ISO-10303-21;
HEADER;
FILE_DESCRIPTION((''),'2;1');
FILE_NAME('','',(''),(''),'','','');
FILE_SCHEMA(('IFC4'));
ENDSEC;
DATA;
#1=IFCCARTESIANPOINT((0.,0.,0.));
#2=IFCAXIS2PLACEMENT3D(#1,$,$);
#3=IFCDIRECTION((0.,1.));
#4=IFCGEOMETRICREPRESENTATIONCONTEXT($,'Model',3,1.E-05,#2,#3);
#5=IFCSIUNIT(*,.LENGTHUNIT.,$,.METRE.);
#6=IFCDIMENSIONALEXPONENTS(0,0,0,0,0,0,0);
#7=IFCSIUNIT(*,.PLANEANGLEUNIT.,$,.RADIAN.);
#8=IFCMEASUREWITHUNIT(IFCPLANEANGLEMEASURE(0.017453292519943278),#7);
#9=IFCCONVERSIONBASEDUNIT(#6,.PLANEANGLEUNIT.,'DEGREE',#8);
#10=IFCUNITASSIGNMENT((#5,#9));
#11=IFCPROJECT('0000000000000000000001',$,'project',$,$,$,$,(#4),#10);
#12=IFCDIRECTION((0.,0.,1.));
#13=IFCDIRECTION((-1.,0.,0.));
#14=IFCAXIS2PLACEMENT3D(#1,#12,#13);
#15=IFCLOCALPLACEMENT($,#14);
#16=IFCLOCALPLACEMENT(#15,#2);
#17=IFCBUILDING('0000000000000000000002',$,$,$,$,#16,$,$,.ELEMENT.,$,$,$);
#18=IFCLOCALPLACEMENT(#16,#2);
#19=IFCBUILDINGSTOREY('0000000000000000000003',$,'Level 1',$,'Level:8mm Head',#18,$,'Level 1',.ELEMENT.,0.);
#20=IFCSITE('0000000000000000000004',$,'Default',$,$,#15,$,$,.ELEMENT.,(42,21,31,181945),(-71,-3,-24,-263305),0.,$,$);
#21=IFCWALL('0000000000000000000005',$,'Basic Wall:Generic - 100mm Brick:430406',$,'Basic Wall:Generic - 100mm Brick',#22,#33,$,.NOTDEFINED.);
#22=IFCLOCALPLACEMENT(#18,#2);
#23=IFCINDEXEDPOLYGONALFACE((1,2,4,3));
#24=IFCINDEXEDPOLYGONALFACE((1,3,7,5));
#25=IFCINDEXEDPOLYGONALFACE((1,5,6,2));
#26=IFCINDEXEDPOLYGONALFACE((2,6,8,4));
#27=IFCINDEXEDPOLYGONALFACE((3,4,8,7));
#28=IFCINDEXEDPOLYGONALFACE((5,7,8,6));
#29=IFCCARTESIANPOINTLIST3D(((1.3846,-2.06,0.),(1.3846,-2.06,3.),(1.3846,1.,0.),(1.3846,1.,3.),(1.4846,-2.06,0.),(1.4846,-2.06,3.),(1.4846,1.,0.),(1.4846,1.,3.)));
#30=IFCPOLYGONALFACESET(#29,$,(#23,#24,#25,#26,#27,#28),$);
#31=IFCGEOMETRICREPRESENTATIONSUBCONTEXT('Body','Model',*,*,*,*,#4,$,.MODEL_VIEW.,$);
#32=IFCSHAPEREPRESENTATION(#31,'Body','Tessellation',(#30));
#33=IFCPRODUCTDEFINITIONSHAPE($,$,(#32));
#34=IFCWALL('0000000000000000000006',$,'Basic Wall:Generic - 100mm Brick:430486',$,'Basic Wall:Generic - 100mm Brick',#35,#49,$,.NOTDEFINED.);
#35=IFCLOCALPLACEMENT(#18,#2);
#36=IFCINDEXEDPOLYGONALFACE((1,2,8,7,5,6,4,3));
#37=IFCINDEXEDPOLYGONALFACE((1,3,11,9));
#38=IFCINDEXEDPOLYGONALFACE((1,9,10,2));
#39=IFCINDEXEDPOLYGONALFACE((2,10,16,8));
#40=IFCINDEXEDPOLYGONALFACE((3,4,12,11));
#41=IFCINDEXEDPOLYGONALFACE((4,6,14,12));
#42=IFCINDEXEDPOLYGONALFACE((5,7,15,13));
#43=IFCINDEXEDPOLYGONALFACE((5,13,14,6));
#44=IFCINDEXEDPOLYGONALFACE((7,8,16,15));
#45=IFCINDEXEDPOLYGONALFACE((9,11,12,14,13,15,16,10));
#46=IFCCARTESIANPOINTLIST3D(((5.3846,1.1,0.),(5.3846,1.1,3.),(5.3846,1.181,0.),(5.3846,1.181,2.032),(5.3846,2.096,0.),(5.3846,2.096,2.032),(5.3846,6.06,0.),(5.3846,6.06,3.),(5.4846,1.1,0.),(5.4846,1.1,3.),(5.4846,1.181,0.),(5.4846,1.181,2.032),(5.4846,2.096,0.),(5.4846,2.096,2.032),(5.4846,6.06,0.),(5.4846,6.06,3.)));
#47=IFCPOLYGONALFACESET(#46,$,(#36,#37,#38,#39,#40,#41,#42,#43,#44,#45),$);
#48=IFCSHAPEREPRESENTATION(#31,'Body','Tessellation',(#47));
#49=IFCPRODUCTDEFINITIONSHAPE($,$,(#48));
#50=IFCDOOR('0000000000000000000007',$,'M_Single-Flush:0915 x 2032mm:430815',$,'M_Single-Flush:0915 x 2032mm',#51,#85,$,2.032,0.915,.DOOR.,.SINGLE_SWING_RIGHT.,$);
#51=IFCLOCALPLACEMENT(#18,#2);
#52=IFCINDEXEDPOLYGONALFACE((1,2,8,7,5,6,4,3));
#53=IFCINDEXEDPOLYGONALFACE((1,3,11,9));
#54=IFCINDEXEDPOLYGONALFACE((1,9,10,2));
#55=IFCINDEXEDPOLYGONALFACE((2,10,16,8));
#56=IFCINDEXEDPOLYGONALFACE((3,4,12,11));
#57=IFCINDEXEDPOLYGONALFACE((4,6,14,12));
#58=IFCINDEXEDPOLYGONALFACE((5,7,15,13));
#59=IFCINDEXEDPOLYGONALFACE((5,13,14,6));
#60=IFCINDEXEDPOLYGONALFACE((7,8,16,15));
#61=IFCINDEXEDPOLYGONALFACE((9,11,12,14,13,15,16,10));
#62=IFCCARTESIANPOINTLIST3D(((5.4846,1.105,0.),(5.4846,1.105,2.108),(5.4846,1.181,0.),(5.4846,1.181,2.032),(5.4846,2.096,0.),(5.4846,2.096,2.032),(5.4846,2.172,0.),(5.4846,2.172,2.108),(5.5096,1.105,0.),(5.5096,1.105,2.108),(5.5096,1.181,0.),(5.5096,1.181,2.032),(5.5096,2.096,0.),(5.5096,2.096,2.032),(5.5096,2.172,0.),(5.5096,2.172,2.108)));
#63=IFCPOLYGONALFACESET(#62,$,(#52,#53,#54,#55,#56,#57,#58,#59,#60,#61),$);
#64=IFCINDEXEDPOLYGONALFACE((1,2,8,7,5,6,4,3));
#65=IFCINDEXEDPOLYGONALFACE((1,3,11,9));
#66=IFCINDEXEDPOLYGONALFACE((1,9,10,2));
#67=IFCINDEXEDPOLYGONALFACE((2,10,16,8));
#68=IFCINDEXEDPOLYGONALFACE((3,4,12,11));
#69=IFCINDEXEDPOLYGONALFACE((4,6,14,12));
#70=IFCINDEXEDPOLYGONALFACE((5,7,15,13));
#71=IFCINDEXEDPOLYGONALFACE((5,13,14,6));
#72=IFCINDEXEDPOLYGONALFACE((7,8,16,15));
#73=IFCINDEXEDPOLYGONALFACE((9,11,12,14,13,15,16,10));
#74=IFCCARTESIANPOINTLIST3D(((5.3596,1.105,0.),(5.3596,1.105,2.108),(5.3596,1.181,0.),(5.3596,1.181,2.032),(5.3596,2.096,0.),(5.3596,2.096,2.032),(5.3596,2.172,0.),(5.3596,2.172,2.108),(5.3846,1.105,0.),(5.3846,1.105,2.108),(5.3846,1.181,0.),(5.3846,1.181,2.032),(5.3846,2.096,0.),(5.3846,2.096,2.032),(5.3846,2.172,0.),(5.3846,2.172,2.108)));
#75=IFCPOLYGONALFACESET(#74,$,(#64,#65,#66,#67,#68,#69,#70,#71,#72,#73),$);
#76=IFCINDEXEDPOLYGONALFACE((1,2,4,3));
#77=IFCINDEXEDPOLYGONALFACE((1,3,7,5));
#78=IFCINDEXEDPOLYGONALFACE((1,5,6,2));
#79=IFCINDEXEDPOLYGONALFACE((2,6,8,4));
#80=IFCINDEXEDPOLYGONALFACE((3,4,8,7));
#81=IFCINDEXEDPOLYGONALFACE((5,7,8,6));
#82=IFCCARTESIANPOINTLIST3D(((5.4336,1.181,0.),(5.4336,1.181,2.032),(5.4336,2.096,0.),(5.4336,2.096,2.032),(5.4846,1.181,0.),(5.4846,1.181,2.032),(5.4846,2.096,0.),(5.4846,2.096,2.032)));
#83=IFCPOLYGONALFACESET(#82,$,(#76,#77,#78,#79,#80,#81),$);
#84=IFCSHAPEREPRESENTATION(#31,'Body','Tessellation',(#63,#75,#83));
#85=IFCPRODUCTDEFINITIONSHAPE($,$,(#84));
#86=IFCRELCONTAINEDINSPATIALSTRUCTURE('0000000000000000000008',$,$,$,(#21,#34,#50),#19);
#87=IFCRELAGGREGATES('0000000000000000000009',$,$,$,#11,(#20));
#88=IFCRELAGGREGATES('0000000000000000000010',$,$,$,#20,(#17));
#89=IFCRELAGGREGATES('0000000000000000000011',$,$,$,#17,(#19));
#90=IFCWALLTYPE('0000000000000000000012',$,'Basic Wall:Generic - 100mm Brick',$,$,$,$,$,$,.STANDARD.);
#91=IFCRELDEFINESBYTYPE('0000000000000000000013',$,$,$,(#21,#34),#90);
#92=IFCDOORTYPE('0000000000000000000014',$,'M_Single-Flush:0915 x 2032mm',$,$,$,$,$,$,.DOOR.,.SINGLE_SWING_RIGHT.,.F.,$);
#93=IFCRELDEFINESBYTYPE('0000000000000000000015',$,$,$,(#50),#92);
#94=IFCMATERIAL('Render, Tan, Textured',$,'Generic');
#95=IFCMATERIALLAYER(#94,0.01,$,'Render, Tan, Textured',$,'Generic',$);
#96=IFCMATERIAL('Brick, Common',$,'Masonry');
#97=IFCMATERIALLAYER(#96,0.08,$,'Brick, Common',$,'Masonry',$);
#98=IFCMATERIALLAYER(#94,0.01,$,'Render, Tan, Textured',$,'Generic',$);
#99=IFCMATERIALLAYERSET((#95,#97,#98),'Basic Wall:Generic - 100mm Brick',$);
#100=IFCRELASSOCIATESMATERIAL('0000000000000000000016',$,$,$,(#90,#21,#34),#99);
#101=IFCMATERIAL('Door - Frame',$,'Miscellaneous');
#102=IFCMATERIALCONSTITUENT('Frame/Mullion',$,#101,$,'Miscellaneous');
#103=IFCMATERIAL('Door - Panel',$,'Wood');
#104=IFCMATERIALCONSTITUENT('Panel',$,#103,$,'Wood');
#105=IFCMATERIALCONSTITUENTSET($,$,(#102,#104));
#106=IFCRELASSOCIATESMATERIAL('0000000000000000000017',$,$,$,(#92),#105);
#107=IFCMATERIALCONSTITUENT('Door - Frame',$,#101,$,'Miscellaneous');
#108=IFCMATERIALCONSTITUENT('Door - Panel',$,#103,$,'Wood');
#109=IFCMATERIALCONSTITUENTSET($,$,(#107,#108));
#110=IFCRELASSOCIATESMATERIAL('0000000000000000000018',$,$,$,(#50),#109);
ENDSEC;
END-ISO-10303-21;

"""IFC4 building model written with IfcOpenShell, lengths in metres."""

from ifc_helpers import new_model, entity, si_unit, converted_unit, direction, frame, frame_2d, origin, place, context, subcontext, project, spatial, polyline, rectangle, outline, extrude, source, transform, mapped, material, layer, layer_set, layer_usage, constituent, constituent_set, type_object, type_shapes, element, fill, save


model = new_model("IFC4")

# Units and contexts
model_context = context("Model", 3, precision=1e-05, world=origin(), true_north=direction((0.0, 1.0)))
body_context = subcontext(model_context, "Body", "Model", "MODEL_VIEW")
ifc_project = project(units=[si_unit("LENGTHUNIT", "METRE"), converted_unit("PLANEANGLEUNIT", "DEGREE", entity("IfcPlaneAngleMeasure", 0.017453292519943278), si_unit("PLANEANGLEUNIT", "RADIAN"), dimensions=[0, 0, 0, 0, 0, 0, 0])], contexts=[model_context])

# Site, building, storey
site_placement = place(None, frame((0.0, 0.0, 0.0), z_axis=(0.0, 0.0, 1.0), x_axis=(-1.0, 0.0, 0.0)))
site = spatial("IfcSite", under=ifc_project, at=site_placement, Name="Default", CompositionType="ELEMENT", RefLatitude=(42, 21, 31, 181945), RefLongitude=(-71, -3, -24, -263305), RefElevation=0.0)
building_placement = place(site_placement, origin())
building = spatial("IfcBuilding", under=site, at=building_placement, CompositionType="ELEMENT")
storey_placement = place(building_placement, origin())
storey = spatial("IfcBuildingStorey", under=building, at=storey_placement, Name="Level 1", ObjectType="Level:8mm Head", LongName="Level 1", CompositionType="ELEMENT", Elevation=0.0)

# Shared definitions
ifc_material_1 = material(Name="Brick, Common", Category="Masonry")

# Shared definitions
ifc_material_2 = material(Name="Render, Tan, Textured", Category="Generic")
ifc_layer_1 = layer(ifc_material_2, 0.01, Name="Render, Tan, Textured", Category="Generic")
ifc_layer_2 = layer(ifc_material_1, 0.08, Name="Brick, Common", Category="Masonry")
ifc_layer_3 = layer(ifc_material_2, 0.01, Name="Render, Tan, Textured", Category="Generic")
ifc_layer_set_1 = layer_set([ifc_layer_1, ifc_layer_2, ifc_layer_3], Name="Basic Wall:Generic - 100mm Brick")
ifc_layer_usage_1 = layer_usage(ifc_layer_set_1, "AXIS2", "NEGATIVE", 0.05)
wall_type_1 = type_object("IfcWallType", Name="Basic Wall:Generic - 100mm Brick", PredefinedType="STANDARD", material=ifc_layer_set_1)

# Shared definitions
ifc_material_3 = material(Name="Door - Frame", Category="Miscellaneous")
ifc_material_4 = material(Name="Door - Panel", Category="Wood")
ifc_constituent_1 = constituent(ifc_material_3, Name="Frame/Mullion", Category="Miscellaneous")
ifc_constituent_2 = constituent(ifc_material_4, Name="Panel", Category="Wood")
ifc_constituent_set_1 = constituent_set(constituents=[ifc_constituent_1, ifc_constituent_2])
door_type_1 = type_object("IfcDoorType", Name="M_Single-Flush:0915 x 2032mm", OperationType="SINGLE_SWING_RIGHT", ParameterTakesPrecedence=False, PredefinedType="DOOR", material=ifc_constituent_set_1)
shared_shape_1 = source(origin(), body_context, "Body", "SweptSolid", [
    extrude(outline(polyline([(-0.5335, -1.073), (0.5335, -1.073), (0.5335, 1.035), (0.4575, 1.035), (0.4575, -0.997), (-0.4575, -0.997), (-0.4575, 1.035), (-0.5335, 1.035), (-0.5335, -1.073)])), frame((0.4575, 0.1, 1.035), z_axis=(0.0, 1.0, 0.0), x_axis=(1.0, 0.0, 0.0)), (0.0, 0.0, 1.0), 0.025),
    extrude(outline(polyline([(-1.073, -0.5335), (1.035, -0.5335), (1.035, -0.4575), (-0.997, -0.4575), (-0.997, 0.4575), (1.035, 0.4575), (1.035, 0.5335), (-1.073, 0.5335), (-1.073, -0.5335)])), frame((0.4575, -0.025, 1.035), z_axis=(0.0, 1.0, 0.0), x_axis=(0.0, 0.0, -1.0)), (0.0, 0.0, 1.0), 0.025),
    extrude(rectangle(XDim=0.051, YDim=0.915, at=frame_2d((0.0, 0.0), x_axis=(1.0, 0.0))), frame((0.4575, 0.0745, 0.0), z_axis=(0.0, 0.0, 1.0), x_axis=(0.0, 1.0, 0.0)), (0.0, 0.0, 1.0), 2.032),
])
type_shapes(door_type_1, [shared_shape_1])

# Wall
wall_1_placement = place(storey_placement, frame((1.4346, 1.0, 0.0), z_axis=(0.0, 0.0, 1.0), x_axis=(0.0, -1.0, 0.0)))
element("IfcWall", 1, at=wall_1_placement, inside=storey, type_object=wall_type_1, material=ifc_layer_usage_1, Name="Basic Wall:Generic - 100mm Brick:430406", ObjectType="Basic Wall:Generic - 100mm Brick", PredefinedType="NOTDEFINED", context=body_context, shape_type="SweptSolid", body=[
    extrude(rectangle(XDim=3.06, YDim=0.1, at=frame_2d((1.53, 0.0), x_axis=(-1.0, 0.0))), origin(), (0.0, 0.0, 1.0), 3.0),
])

# Wall, opening, door
wall_2_placement = place(storey_placement, frame((5.4346, 6.06, 0.0), z_axis=(0.0, 0.0, 1.0), x_axis=(0.0, -1.0, 0.0)))
wall_2 = element("IfcWall", 2, at=wall_2_placement, inside=storey, type_object=wall_type_1, material=ifc_layer_usage_1, Name="Basic Wall:Generic - 100mm Brick:430486", ObjectType="Basic Wall:Generic - 100mm Brick", PredefinedType="NOTDEFINED", context=body_context, shape_type="SweptSolid", body=[
    extrude(rectangle(XDim=4.96, YDim=0.1, at=frame_2d((2.48, 0.0), x_axis=(1.0, 0.0))), origin(), (0.0, 0.0, 1.0), 3.0),
])
opening_1_placement = place(wall_2_placement, frame((3.964, -0.05, 0.0)))
opening_1 = element("IfcOpeningElement", 3, at=opening_1_placement, cuts=wall_2, PredefinedType="OPENING", context=body_context, shape_type="SweptSolid", body=[
    extrude(rectangle(XDim=0.915, YDim=2.032, at=frame_2d((1.016, 0.4575), x_axis=(0.0, 1.0))), frame((0.0, 0.0, 0.0), z_axis=(0.0, 1.0, 0.0), x_axis=(0.0, 0.0, 1.0)), (0.0, 0.0, 1.0), 0.1),
])
ifc_constituent_3 = constituent(ifc_material_3, Name="Door - Frame", Category="Miscellaneous")
ifc_constituent_4 = constituent(ifc_material_4, Name="Door - Panel", Category="Wood")
ifc_constituent_set_2 = constituent_set(constituents=[ifc_constituent_3, ifc_constituent_4])
door_1_placement = place(opening_1_placement, origin())
door_1 = element("IfcDoor", 4, at=door_1_placement, inside=storey, type_object=door_type_1, material=ifc_constituent_set_2, Name="M_Single-Flush:0915 x 2032mm:430815", ObjectType="M_Single-Flush:0915 x 2032mm", OperationType="SINGLE_SWING_RIGHT", OverallHeight=2.032, OverallWidth=0.915, PredefinedType="DOOR", context=body_context, shape_type="MappedRepresentation", body=[
    mapped(shared_shape_1, transform((0.0, 0.0, 0.0), scale=1.0)),
])
fill(opening_1, door_1)

save(model, "model.ifc")
